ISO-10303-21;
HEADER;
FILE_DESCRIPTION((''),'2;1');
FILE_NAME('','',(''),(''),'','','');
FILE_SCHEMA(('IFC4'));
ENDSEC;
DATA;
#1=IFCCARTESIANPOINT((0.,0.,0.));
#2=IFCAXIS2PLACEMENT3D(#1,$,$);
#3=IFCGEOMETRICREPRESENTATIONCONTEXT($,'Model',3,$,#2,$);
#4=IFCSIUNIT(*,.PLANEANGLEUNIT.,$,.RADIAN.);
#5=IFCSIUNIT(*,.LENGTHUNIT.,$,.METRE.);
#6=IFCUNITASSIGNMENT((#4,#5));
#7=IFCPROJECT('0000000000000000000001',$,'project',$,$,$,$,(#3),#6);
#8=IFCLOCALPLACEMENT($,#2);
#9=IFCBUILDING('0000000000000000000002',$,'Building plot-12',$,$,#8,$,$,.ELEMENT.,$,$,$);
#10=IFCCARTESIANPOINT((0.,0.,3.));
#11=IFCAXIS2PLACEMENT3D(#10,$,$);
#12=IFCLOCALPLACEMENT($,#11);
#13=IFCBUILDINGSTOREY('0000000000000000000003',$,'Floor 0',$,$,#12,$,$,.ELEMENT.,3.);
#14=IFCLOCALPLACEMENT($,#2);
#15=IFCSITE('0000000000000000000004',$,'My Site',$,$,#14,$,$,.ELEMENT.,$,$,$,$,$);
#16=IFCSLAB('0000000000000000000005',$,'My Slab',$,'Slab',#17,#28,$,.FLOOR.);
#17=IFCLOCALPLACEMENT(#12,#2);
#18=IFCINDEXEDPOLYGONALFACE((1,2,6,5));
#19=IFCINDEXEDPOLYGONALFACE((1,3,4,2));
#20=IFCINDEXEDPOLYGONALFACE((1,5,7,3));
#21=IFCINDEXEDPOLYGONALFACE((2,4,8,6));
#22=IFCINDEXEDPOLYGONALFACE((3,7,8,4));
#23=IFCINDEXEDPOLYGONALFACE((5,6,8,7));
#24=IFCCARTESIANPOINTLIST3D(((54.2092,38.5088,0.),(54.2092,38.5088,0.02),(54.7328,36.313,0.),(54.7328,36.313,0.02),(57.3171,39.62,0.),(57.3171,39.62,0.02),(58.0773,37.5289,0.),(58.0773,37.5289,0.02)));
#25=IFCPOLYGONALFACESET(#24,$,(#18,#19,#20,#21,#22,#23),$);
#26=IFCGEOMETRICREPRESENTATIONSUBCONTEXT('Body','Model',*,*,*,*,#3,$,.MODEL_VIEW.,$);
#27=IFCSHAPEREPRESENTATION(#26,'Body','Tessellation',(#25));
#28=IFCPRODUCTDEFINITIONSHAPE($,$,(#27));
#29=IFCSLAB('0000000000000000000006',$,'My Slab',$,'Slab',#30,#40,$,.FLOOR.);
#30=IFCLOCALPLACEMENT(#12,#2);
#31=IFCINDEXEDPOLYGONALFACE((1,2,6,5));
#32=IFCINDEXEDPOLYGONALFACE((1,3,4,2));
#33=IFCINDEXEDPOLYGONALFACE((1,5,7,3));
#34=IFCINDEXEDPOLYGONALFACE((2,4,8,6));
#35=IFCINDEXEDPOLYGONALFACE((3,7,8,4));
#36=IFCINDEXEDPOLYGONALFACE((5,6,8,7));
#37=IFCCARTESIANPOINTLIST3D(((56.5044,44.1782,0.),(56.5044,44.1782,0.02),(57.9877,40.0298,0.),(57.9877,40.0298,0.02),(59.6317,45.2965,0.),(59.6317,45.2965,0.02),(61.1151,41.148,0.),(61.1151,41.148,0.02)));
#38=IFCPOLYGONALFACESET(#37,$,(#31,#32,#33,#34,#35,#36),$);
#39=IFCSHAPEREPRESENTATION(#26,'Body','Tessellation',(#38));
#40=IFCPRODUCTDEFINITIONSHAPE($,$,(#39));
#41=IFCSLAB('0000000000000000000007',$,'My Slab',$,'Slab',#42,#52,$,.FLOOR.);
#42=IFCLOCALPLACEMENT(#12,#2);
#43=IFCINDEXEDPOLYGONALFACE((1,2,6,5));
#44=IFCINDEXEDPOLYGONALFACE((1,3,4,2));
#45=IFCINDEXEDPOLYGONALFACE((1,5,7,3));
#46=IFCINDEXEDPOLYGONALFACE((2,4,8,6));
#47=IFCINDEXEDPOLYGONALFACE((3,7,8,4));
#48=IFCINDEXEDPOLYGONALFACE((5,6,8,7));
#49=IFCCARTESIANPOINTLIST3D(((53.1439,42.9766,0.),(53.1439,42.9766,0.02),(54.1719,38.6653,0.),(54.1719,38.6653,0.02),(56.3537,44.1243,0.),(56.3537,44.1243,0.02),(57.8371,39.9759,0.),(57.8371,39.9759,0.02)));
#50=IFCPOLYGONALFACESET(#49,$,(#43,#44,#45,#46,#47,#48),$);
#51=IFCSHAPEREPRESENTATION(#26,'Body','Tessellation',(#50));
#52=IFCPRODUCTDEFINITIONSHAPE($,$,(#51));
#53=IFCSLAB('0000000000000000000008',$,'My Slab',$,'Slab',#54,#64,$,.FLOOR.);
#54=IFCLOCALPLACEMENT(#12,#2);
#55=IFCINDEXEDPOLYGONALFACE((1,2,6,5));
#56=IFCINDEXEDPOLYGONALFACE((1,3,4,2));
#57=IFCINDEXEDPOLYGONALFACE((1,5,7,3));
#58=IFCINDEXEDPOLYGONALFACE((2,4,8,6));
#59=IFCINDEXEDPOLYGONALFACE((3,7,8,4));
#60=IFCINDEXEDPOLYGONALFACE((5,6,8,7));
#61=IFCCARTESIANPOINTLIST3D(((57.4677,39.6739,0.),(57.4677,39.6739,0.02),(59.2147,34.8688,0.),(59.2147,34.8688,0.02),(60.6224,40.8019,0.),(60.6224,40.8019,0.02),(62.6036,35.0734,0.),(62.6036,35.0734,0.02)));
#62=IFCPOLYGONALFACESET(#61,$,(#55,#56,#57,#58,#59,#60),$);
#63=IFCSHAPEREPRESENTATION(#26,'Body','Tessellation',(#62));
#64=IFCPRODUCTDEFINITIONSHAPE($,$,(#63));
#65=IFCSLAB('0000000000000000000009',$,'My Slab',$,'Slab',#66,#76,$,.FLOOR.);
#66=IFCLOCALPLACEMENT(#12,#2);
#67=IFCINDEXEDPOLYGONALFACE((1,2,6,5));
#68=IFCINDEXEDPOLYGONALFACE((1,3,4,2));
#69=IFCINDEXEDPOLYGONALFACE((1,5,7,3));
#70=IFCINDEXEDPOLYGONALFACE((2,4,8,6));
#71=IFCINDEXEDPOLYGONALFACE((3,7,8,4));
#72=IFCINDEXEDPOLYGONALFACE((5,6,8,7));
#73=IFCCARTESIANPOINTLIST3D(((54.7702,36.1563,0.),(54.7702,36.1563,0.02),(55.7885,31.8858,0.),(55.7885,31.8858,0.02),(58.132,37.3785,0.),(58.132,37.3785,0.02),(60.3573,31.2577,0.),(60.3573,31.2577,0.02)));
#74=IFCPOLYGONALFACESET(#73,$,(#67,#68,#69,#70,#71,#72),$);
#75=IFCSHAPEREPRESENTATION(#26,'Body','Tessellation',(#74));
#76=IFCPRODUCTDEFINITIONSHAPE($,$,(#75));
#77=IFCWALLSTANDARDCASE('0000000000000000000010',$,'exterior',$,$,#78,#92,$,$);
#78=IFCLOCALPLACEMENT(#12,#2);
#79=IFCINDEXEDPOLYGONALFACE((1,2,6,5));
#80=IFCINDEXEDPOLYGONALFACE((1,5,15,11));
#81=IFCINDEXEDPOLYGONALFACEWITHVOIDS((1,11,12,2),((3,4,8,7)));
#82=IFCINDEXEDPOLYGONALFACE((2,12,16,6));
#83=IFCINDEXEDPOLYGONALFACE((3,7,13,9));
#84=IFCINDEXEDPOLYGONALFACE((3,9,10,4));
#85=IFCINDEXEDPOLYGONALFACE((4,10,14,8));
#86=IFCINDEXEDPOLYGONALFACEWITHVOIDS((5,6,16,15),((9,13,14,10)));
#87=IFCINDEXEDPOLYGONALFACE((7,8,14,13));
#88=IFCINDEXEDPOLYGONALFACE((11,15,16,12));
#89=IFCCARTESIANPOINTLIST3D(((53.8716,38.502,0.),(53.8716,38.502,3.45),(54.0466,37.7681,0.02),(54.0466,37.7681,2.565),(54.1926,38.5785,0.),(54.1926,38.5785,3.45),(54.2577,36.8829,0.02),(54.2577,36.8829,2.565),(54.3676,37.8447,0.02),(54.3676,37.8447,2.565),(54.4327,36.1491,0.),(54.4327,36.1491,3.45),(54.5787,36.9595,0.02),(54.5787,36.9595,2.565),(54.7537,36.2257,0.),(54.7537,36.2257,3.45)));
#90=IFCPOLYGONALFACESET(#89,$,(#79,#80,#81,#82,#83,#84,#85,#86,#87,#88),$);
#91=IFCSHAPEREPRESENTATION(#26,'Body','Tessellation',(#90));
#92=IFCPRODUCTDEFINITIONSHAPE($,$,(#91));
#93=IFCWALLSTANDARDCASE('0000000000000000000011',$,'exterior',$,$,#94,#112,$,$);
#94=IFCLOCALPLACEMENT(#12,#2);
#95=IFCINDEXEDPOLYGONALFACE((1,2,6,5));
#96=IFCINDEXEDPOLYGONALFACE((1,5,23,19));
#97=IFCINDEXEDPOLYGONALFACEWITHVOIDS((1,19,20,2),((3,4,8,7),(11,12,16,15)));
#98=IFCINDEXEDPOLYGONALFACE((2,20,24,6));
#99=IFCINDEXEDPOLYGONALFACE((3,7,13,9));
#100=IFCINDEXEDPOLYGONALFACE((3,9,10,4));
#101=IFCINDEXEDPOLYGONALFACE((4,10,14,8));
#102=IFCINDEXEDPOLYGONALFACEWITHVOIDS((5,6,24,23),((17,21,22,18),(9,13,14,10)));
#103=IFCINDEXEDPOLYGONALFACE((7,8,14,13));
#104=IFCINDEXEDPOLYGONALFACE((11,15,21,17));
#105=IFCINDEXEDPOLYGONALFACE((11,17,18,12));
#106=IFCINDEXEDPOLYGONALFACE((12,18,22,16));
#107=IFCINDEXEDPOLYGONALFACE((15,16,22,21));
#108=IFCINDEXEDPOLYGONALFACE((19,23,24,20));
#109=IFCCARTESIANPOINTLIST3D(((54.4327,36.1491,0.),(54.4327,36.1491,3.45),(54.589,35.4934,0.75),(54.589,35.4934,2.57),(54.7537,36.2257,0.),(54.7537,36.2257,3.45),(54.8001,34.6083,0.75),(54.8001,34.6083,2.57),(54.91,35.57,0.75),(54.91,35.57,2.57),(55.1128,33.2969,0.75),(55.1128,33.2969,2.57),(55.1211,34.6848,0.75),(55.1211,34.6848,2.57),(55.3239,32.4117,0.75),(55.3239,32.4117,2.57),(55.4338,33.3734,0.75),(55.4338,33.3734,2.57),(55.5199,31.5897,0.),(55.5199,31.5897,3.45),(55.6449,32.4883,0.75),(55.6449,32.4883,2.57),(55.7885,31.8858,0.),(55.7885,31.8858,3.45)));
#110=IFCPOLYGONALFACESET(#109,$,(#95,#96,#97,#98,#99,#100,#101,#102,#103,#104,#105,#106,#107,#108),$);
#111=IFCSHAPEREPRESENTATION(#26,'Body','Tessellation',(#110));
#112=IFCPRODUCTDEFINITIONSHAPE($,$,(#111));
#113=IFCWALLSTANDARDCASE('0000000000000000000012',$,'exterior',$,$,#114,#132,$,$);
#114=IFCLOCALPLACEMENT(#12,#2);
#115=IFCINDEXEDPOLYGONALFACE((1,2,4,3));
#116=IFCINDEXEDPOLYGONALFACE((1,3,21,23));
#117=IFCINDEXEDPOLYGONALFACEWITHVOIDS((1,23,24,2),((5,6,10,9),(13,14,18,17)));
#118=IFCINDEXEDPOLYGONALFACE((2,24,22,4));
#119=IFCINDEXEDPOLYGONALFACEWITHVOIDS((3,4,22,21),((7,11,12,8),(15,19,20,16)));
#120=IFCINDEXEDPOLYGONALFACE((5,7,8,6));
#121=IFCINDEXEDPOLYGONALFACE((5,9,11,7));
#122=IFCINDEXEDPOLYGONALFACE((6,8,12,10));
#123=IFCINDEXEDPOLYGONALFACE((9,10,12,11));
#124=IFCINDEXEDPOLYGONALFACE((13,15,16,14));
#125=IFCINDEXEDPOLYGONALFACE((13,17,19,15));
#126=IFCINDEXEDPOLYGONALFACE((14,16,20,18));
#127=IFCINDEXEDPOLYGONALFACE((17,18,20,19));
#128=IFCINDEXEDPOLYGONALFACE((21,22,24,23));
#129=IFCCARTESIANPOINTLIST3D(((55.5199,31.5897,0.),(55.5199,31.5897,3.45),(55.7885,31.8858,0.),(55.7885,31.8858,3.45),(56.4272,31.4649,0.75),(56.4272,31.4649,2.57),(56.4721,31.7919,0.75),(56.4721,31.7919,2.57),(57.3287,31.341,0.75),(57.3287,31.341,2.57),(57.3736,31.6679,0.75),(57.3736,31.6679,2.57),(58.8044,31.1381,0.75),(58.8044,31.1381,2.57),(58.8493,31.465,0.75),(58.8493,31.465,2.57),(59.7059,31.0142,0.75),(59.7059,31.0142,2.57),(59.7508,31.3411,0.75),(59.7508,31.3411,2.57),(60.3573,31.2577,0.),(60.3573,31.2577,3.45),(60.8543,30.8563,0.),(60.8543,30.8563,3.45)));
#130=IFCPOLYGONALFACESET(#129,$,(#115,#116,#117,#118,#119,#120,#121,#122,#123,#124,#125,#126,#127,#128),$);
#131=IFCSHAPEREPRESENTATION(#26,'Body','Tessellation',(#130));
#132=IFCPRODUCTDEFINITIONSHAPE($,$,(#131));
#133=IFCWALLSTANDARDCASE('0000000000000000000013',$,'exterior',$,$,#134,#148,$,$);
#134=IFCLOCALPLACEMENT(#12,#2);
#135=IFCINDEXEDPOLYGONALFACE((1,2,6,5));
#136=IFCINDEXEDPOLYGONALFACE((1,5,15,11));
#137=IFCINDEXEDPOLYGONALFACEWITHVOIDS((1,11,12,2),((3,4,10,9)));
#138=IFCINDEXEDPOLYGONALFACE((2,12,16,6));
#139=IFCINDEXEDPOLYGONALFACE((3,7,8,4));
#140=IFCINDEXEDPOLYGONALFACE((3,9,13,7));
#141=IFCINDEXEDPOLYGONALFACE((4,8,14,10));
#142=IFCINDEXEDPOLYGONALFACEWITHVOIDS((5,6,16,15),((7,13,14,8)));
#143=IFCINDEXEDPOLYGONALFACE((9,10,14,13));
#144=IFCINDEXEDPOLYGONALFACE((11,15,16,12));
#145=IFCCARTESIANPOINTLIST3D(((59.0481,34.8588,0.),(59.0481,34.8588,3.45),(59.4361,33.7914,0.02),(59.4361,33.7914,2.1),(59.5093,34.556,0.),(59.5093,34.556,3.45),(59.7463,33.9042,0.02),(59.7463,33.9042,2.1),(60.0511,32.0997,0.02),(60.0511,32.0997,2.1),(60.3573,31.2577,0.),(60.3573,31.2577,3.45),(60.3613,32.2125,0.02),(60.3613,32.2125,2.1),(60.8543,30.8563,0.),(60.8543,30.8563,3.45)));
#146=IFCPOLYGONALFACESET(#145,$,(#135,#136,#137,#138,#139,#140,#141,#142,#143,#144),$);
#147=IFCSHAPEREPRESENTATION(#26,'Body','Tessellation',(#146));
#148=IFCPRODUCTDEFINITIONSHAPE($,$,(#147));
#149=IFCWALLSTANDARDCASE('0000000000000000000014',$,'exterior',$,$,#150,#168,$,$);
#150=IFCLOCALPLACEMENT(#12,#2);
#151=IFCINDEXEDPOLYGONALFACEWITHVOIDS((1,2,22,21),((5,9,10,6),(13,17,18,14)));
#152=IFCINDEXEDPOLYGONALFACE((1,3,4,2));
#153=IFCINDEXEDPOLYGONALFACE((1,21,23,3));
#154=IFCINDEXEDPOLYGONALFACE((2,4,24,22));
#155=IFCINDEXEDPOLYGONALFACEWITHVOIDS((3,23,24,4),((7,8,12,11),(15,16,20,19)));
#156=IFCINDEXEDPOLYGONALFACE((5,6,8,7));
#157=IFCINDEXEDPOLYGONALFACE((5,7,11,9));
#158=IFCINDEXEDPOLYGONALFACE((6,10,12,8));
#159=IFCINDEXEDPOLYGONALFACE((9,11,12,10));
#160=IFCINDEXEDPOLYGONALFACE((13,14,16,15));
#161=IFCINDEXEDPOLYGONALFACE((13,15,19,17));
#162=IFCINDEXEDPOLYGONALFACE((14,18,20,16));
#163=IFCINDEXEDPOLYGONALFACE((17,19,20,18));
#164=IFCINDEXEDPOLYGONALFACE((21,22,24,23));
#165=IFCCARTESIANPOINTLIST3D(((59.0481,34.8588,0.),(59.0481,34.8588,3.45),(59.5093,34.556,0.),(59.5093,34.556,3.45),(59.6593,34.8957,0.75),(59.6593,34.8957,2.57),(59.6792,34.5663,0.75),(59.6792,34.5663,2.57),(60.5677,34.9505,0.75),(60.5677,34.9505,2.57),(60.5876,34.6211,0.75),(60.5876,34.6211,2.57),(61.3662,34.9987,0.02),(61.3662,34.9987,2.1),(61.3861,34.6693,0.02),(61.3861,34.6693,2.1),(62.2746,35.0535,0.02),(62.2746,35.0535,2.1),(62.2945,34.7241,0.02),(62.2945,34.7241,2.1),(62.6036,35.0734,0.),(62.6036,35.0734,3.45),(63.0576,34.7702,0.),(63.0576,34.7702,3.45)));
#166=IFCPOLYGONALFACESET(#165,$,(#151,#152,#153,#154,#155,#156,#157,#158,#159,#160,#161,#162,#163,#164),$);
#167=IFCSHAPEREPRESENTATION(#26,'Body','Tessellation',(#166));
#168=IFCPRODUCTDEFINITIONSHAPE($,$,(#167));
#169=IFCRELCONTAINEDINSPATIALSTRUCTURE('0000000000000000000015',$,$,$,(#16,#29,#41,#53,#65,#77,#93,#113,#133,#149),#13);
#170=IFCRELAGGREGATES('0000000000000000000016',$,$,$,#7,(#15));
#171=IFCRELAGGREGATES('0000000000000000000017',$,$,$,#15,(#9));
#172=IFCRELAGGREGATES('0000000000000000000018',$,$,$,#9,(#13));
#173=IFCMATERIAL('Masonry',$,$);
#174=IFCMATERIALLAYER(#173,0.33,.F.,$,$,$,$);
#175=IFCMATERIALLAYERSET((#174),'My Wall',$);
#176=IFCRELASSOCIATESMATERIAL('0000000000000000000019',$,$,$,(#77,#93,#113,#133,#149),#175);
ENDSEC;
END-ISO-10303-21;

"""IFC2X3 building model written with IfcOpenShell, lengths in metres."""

from ifc_helpers import new_model, si_unit, frame, origin, place, context, subcontext, project, spatial, polyline, outline, extrude, material, layer, layer_set, layer_usage, element, save


model = new_model("IFC2X3")

# Units and contexts
model_context = context("Model", 3, world=origin())
body_context = subcontext(model_context, "Body", "Model", "MODEL_VIEW")
ifc_project = project(units=[si_unit("PLANEANGLEUNIT", "RADIAN"), si_unit("LENGTHUNIT", "METRE")], contexts=[model_context])

# Site, building, storey
site_placement = place(None, origin())
site = spatial("IfcSite", under=ifc_project, at=site_placement, Name="My Site", CompositionType="ELEMENT")
building_placement = place(None, origin())
building = spatial("IfcBuilding", under=site, at=building_placement, Name="Building plot-12", CompositionType="ELEMENT")
storey_placement = place(None, frame((0.0, 0.0, 3.0)))
storey = spatial("IfcBuildingStorey", under=building, at=storey_placement, Name="Floor 0", CompositionType="ELEMENT", Elevation=3.0)

# Slabs
slab_1_placement = place(storey_placement, origin())
element("IfcSlab", 1, at=slab_1_placement, inside=storey, Name="My Slab", ObjectType="Slab", PredefinedType="FLOOR", context=body_context, shape_type="SweptSolid", body=[
    extrude(outline(polyline([(54.2092, 38.5088), (54.7328, 36.313), (58.0773, 37.5289), (57.3171, 39.62), (54.2092, 38.5088)])), origin(), (0.0, 0.0, 1.0), 0.02),
])
slab_2_placement = place(storey_placement, origin())
element("IfcSlab", 2, at=slab_2_placement, inside=storey, Name="My Slab", ObjectType="Slab", PredefinedType="FLOOR", context=body_context, shape_type="SweptSolid", body=[
    extrude(outline(polyline([(59.6317, 45.2965), (56.5044, 44.1782), (57.9877, 40.0298), (61.1151, 41.148), (59.6317, 45.2965)])), origin(), (0.0, 0.0, 1.0), 0.02),
])
slab_3_placement = place(storey_placement, origin())
element("IfcSlab", 3, at=slab_3_placement, inside=storey, Name="My Slab", ObjectType="Slab", PredefinedType="FLOOR", context=body_context, shape_type="SweptSolid", body=[
    extrude(outline(polyline([(56.3537, 44.1243), (53.1439, 42.9766), (54.1719, 38.6653), (57.8371, 39.9759), (56.3537, 44.1243)])), origin(), (0.0, 0.0, 1.0), 0.02),
])
slab_4_placement = place(storey_placement, origin())
element("IfcSlab", 4, at=slab_4_placement, inside=storey, Name="My Slab", ObjectType="Slab", PredefinedType="FLOOR", context=body_context, shape_type="SweptSolid", body=[
    extrude(outline(polyline([(57.4677, 39.6739), (59.2147, 34.8688), (62.6036, 35.0734), (60.6224, 40.8019), (57.4677, 39.6739)])), origin(), (0.0, 0.0, 1.0), 0.02),
])
slab_5_placement = place(storey_placement, origin())
element("IfcSlab", 5, at=slab_5_placement, inside=storey, Name="My Slab", ObjectType="Slab", PredefinedType="FLOOR", context=body_context, shape_type="SweptSolid", body=[
    extrude(outline(polyline([(54.7702, 36.1563), (55.7885, 31.8858), (60.3573, 31.2577), (58.132, 37.3785), (54.7702, 36.1563)])), origin(), (0.0, 0.0, 1.0), 0.02),
])

# Wall, opening
ifc_material = material(Name="Masonry")
ifc_layer = layer(ifc_material, 0.33, ventilated=False)
ifc_layer_set = layer_set([ifc_layer], Name="My Wall")
ifc_layer_usage = layer_usage(ifc_layer_set, "AXIS2", "NEGATIVE", 0.08)
wall_1_placement = place(storey_placement, origin())
wall_1 = element("IfcWallStandardCase", 6, at=wall_1_placement, inside=storey, material=ifc_layer_usage, Name="exterior", context=body_context, shape_type="SweptSolid", body=[
    extrude(outline(polyline([(54.1926, 38.5785), (53.8716, 38.502), (54.4327, 36.1491), (54.7537, 36.2257), (54.1926, 38.5785)])), origin(), (0.0, 0.0, 1.0), 3.45),
])
opening_1_placement = place(storey_placement, frame((0.0, 0.0, 0.02)))
element("IfcOpeningElement", 7, at=opening_1_placement, cuts=wall_1, ObjectType="Opening", context=body_context, shape_type="SweptSolid", body=[
    extrude(outline(polyline([(54.0466, 37.7681), (54.2577, 36.8829), (54.5787, 36.9595), (54.3676, 37.8447), (54.0466, 37.7681)])), origin(), (0.0, 0.0, 1.0), 2.545),
])

# Walls, openings
wall_2_placement = place(storey_placement, origin())
wall_2 = element("IfcWallStandardCase", 8, at=wall_2_placement, inside=storey, material=ifc_layer_usage, Name="exterior", context=body_context, shape_type="SweptSolid", body=[
    extrude(outline(polyline([(54.7537, 36.2257), (54.4327, 36.1491), (55.5199, 31.5897), (55.7885, 31.8858), (54.7537, 36.2257)])), origin(), (0.0, 0.0, 1.0), 3.45),
])
opening_2_placement = place(storey_placement, frame((0.0, 0.0, 0.75)))
element("IfcOpeningElement", 9, at=opening_2_placement, cuts=wall_2, ObjectType="Opening", context=body_context, shape_type="SweptSolid", body=[
    extrude(outline(polyline([(54.589, 35.4934), (54.8001, 34.6083), (55.1211, 34.6848), (54.91, 35.57), (54.589, 35.4934)])), origin(), (0.0, 0.0, 1.0), 1.82),
])
opening_3_placement = place(storey_placement, frame((0.0, 0.0, 0.75)))
element("IfcOpeningElement", 10, at=opening_3_placement, cuts=wall_2, ObjectType="Opening", context=body_context, shape_type="SweptSolid", body=[
    extrude(outline(polyline([(55.1128, 33.2969), (55.3239, 32.4117), (55.6449, 32.4883), (55.4338, 33.3734), (55.1128, 33.2969)])), origin(), (0.0, 0.0, 1.0), 1.82),
])
wall_3_placement = place(storey_placement, origin())
wall_3 = element("IfcWallStandardCase", 11, at=wall_3_placement, inside=storey, material=ifc_layer_usage, Name="exterior", context=body_context, shape_type="SweptSolid", body=[
    extrude(outline(polyline([(55.7885, 31.8858), (55.5199, 31.5897), (60.8543, 30.8563), (60.3573, 31.2577), (55.7885, 31.8858)])), origin(), (0.0, 0.0, 1.0), 3.45),
])
opening_4_placement = place(storey_placement, frame((0.0, 0.0, 0.75)))
element("IfcOpeningElement", 12, at=opening_4_placement, cuts=wall_3, ObjectType="Opening", context=body_context, shape_type="SweptSolid", body=[
    extrude(outline(polyline([(56.4272, 31.4649), (57.3287, 31.341), (57.3736, 31.6679), (56.4721, 31.7919), (56.4272, 31.4649)])), origin(), (0.0, 0.0, 1.0), 1.82),
])
opening_5_placement = place(storey_placement, frame((0.0, 0.0, 0.75)))
element("IfcOpeningElement", 13, at=opening_5_placement, cuts=wall_3, ObjectType="Opening", context=body_context, shape_type="SweptSolid", body=[
    extrude(outline(polyline([(58.8044, 31.1381), (59.7059, 31.0142), (59.7508, 31.3411), (58.8493, 31.465), (58.8044, 31.1381)])), origin(), (0.0, 0.0, 1.0), 1.82),
])

# Wall, opening
wall_4_placement = place(storey_placement, origin())
wall_4 = element("IfcWallStandardCase", 14, at=wall_4_placement, inside=storey, material=ifc_layer_usage, Name="exterior", context=body_context, shape_type="SweptSolid", body=[
    extrude(outline(polyline([(60.3573, 31.2577), (60.8543, 30.8563), (59.5093, 34.556), (59.0481, 34.8588), (60.3573, 31.2577)])), origin(), (0.0, 0.0, 1.0), 3.45),
])
opening_6_placement = place(storey_placement, frame((0.0, 0.0, 0.02)))
element("IfcOpeningElement", 15, at=opening_6_placement, cuts=wall_4, ObjectType="Opening", context=body_context, shape_type="SweptSolid", body=[
    extrude(outline(polyline([(60.3613, 32.2125), (59.7463, 33.9042), (59.4361, 33.7914), (60.0511, 32.0997), (60.3613, 32.2125)])), origin(), (0.0, 0.0, 1.0), 2.08),
])

# Wall, openings
wall_5_placement = place(storey_placement, origin())
wall_5 = element("IfcWallStandardCase", 16, at=wall_5_placement, inside=storey, material=ifc_layer_usage, Name="exterior", context=body_context, shape_type="SweptSolid", body=[
    extrude(outline(polyline([(59.0481, 34.8588), (59.5093, 34.556), (63.0576, 34.7702), (62.6036, 35.0734), (59.0481, 34.8588)])), origin(), (0.0, 0.0, 1.0), 3.45),
])
opening_7_placement = place(storey_placement, frame((0.0, 0.0, 0.75)))
element("IfcOpeningElement", 17, at=opening_7_placement, cuts=wall_5, ObjectType="Opening", context=body_context, shape_type="SweptSolid", body=[
    extrude(outline(polyline([(59.6792, 34.5663), (60.5876, 34.6211), (60.5677, 34.9505), (59.6593, 34.8957), (59.6792, 34.5663)])), origin(), (0.0, 0.0, 1.0), 1.82),
])
opening_8_placement = place(storey_placement, frame((0.0, 0.0, 0.02)))
element("IfcOpeningElement", 18, at=opening_8_placement, cuts=wall_5, ObjectType="Opening", context=body_context, shape_type="SweptSolid", body=[
    extrude(outline(polyline([(61.3861, 34.6693), (62.2945, 34.7241), (62.2746, 35.0535), (61.3662, 34.9987), (61.3861, 34.6693)])), origin(), (0.0, 0.0, 1.0), 2.08),
])

save(model, "model.ifc")
